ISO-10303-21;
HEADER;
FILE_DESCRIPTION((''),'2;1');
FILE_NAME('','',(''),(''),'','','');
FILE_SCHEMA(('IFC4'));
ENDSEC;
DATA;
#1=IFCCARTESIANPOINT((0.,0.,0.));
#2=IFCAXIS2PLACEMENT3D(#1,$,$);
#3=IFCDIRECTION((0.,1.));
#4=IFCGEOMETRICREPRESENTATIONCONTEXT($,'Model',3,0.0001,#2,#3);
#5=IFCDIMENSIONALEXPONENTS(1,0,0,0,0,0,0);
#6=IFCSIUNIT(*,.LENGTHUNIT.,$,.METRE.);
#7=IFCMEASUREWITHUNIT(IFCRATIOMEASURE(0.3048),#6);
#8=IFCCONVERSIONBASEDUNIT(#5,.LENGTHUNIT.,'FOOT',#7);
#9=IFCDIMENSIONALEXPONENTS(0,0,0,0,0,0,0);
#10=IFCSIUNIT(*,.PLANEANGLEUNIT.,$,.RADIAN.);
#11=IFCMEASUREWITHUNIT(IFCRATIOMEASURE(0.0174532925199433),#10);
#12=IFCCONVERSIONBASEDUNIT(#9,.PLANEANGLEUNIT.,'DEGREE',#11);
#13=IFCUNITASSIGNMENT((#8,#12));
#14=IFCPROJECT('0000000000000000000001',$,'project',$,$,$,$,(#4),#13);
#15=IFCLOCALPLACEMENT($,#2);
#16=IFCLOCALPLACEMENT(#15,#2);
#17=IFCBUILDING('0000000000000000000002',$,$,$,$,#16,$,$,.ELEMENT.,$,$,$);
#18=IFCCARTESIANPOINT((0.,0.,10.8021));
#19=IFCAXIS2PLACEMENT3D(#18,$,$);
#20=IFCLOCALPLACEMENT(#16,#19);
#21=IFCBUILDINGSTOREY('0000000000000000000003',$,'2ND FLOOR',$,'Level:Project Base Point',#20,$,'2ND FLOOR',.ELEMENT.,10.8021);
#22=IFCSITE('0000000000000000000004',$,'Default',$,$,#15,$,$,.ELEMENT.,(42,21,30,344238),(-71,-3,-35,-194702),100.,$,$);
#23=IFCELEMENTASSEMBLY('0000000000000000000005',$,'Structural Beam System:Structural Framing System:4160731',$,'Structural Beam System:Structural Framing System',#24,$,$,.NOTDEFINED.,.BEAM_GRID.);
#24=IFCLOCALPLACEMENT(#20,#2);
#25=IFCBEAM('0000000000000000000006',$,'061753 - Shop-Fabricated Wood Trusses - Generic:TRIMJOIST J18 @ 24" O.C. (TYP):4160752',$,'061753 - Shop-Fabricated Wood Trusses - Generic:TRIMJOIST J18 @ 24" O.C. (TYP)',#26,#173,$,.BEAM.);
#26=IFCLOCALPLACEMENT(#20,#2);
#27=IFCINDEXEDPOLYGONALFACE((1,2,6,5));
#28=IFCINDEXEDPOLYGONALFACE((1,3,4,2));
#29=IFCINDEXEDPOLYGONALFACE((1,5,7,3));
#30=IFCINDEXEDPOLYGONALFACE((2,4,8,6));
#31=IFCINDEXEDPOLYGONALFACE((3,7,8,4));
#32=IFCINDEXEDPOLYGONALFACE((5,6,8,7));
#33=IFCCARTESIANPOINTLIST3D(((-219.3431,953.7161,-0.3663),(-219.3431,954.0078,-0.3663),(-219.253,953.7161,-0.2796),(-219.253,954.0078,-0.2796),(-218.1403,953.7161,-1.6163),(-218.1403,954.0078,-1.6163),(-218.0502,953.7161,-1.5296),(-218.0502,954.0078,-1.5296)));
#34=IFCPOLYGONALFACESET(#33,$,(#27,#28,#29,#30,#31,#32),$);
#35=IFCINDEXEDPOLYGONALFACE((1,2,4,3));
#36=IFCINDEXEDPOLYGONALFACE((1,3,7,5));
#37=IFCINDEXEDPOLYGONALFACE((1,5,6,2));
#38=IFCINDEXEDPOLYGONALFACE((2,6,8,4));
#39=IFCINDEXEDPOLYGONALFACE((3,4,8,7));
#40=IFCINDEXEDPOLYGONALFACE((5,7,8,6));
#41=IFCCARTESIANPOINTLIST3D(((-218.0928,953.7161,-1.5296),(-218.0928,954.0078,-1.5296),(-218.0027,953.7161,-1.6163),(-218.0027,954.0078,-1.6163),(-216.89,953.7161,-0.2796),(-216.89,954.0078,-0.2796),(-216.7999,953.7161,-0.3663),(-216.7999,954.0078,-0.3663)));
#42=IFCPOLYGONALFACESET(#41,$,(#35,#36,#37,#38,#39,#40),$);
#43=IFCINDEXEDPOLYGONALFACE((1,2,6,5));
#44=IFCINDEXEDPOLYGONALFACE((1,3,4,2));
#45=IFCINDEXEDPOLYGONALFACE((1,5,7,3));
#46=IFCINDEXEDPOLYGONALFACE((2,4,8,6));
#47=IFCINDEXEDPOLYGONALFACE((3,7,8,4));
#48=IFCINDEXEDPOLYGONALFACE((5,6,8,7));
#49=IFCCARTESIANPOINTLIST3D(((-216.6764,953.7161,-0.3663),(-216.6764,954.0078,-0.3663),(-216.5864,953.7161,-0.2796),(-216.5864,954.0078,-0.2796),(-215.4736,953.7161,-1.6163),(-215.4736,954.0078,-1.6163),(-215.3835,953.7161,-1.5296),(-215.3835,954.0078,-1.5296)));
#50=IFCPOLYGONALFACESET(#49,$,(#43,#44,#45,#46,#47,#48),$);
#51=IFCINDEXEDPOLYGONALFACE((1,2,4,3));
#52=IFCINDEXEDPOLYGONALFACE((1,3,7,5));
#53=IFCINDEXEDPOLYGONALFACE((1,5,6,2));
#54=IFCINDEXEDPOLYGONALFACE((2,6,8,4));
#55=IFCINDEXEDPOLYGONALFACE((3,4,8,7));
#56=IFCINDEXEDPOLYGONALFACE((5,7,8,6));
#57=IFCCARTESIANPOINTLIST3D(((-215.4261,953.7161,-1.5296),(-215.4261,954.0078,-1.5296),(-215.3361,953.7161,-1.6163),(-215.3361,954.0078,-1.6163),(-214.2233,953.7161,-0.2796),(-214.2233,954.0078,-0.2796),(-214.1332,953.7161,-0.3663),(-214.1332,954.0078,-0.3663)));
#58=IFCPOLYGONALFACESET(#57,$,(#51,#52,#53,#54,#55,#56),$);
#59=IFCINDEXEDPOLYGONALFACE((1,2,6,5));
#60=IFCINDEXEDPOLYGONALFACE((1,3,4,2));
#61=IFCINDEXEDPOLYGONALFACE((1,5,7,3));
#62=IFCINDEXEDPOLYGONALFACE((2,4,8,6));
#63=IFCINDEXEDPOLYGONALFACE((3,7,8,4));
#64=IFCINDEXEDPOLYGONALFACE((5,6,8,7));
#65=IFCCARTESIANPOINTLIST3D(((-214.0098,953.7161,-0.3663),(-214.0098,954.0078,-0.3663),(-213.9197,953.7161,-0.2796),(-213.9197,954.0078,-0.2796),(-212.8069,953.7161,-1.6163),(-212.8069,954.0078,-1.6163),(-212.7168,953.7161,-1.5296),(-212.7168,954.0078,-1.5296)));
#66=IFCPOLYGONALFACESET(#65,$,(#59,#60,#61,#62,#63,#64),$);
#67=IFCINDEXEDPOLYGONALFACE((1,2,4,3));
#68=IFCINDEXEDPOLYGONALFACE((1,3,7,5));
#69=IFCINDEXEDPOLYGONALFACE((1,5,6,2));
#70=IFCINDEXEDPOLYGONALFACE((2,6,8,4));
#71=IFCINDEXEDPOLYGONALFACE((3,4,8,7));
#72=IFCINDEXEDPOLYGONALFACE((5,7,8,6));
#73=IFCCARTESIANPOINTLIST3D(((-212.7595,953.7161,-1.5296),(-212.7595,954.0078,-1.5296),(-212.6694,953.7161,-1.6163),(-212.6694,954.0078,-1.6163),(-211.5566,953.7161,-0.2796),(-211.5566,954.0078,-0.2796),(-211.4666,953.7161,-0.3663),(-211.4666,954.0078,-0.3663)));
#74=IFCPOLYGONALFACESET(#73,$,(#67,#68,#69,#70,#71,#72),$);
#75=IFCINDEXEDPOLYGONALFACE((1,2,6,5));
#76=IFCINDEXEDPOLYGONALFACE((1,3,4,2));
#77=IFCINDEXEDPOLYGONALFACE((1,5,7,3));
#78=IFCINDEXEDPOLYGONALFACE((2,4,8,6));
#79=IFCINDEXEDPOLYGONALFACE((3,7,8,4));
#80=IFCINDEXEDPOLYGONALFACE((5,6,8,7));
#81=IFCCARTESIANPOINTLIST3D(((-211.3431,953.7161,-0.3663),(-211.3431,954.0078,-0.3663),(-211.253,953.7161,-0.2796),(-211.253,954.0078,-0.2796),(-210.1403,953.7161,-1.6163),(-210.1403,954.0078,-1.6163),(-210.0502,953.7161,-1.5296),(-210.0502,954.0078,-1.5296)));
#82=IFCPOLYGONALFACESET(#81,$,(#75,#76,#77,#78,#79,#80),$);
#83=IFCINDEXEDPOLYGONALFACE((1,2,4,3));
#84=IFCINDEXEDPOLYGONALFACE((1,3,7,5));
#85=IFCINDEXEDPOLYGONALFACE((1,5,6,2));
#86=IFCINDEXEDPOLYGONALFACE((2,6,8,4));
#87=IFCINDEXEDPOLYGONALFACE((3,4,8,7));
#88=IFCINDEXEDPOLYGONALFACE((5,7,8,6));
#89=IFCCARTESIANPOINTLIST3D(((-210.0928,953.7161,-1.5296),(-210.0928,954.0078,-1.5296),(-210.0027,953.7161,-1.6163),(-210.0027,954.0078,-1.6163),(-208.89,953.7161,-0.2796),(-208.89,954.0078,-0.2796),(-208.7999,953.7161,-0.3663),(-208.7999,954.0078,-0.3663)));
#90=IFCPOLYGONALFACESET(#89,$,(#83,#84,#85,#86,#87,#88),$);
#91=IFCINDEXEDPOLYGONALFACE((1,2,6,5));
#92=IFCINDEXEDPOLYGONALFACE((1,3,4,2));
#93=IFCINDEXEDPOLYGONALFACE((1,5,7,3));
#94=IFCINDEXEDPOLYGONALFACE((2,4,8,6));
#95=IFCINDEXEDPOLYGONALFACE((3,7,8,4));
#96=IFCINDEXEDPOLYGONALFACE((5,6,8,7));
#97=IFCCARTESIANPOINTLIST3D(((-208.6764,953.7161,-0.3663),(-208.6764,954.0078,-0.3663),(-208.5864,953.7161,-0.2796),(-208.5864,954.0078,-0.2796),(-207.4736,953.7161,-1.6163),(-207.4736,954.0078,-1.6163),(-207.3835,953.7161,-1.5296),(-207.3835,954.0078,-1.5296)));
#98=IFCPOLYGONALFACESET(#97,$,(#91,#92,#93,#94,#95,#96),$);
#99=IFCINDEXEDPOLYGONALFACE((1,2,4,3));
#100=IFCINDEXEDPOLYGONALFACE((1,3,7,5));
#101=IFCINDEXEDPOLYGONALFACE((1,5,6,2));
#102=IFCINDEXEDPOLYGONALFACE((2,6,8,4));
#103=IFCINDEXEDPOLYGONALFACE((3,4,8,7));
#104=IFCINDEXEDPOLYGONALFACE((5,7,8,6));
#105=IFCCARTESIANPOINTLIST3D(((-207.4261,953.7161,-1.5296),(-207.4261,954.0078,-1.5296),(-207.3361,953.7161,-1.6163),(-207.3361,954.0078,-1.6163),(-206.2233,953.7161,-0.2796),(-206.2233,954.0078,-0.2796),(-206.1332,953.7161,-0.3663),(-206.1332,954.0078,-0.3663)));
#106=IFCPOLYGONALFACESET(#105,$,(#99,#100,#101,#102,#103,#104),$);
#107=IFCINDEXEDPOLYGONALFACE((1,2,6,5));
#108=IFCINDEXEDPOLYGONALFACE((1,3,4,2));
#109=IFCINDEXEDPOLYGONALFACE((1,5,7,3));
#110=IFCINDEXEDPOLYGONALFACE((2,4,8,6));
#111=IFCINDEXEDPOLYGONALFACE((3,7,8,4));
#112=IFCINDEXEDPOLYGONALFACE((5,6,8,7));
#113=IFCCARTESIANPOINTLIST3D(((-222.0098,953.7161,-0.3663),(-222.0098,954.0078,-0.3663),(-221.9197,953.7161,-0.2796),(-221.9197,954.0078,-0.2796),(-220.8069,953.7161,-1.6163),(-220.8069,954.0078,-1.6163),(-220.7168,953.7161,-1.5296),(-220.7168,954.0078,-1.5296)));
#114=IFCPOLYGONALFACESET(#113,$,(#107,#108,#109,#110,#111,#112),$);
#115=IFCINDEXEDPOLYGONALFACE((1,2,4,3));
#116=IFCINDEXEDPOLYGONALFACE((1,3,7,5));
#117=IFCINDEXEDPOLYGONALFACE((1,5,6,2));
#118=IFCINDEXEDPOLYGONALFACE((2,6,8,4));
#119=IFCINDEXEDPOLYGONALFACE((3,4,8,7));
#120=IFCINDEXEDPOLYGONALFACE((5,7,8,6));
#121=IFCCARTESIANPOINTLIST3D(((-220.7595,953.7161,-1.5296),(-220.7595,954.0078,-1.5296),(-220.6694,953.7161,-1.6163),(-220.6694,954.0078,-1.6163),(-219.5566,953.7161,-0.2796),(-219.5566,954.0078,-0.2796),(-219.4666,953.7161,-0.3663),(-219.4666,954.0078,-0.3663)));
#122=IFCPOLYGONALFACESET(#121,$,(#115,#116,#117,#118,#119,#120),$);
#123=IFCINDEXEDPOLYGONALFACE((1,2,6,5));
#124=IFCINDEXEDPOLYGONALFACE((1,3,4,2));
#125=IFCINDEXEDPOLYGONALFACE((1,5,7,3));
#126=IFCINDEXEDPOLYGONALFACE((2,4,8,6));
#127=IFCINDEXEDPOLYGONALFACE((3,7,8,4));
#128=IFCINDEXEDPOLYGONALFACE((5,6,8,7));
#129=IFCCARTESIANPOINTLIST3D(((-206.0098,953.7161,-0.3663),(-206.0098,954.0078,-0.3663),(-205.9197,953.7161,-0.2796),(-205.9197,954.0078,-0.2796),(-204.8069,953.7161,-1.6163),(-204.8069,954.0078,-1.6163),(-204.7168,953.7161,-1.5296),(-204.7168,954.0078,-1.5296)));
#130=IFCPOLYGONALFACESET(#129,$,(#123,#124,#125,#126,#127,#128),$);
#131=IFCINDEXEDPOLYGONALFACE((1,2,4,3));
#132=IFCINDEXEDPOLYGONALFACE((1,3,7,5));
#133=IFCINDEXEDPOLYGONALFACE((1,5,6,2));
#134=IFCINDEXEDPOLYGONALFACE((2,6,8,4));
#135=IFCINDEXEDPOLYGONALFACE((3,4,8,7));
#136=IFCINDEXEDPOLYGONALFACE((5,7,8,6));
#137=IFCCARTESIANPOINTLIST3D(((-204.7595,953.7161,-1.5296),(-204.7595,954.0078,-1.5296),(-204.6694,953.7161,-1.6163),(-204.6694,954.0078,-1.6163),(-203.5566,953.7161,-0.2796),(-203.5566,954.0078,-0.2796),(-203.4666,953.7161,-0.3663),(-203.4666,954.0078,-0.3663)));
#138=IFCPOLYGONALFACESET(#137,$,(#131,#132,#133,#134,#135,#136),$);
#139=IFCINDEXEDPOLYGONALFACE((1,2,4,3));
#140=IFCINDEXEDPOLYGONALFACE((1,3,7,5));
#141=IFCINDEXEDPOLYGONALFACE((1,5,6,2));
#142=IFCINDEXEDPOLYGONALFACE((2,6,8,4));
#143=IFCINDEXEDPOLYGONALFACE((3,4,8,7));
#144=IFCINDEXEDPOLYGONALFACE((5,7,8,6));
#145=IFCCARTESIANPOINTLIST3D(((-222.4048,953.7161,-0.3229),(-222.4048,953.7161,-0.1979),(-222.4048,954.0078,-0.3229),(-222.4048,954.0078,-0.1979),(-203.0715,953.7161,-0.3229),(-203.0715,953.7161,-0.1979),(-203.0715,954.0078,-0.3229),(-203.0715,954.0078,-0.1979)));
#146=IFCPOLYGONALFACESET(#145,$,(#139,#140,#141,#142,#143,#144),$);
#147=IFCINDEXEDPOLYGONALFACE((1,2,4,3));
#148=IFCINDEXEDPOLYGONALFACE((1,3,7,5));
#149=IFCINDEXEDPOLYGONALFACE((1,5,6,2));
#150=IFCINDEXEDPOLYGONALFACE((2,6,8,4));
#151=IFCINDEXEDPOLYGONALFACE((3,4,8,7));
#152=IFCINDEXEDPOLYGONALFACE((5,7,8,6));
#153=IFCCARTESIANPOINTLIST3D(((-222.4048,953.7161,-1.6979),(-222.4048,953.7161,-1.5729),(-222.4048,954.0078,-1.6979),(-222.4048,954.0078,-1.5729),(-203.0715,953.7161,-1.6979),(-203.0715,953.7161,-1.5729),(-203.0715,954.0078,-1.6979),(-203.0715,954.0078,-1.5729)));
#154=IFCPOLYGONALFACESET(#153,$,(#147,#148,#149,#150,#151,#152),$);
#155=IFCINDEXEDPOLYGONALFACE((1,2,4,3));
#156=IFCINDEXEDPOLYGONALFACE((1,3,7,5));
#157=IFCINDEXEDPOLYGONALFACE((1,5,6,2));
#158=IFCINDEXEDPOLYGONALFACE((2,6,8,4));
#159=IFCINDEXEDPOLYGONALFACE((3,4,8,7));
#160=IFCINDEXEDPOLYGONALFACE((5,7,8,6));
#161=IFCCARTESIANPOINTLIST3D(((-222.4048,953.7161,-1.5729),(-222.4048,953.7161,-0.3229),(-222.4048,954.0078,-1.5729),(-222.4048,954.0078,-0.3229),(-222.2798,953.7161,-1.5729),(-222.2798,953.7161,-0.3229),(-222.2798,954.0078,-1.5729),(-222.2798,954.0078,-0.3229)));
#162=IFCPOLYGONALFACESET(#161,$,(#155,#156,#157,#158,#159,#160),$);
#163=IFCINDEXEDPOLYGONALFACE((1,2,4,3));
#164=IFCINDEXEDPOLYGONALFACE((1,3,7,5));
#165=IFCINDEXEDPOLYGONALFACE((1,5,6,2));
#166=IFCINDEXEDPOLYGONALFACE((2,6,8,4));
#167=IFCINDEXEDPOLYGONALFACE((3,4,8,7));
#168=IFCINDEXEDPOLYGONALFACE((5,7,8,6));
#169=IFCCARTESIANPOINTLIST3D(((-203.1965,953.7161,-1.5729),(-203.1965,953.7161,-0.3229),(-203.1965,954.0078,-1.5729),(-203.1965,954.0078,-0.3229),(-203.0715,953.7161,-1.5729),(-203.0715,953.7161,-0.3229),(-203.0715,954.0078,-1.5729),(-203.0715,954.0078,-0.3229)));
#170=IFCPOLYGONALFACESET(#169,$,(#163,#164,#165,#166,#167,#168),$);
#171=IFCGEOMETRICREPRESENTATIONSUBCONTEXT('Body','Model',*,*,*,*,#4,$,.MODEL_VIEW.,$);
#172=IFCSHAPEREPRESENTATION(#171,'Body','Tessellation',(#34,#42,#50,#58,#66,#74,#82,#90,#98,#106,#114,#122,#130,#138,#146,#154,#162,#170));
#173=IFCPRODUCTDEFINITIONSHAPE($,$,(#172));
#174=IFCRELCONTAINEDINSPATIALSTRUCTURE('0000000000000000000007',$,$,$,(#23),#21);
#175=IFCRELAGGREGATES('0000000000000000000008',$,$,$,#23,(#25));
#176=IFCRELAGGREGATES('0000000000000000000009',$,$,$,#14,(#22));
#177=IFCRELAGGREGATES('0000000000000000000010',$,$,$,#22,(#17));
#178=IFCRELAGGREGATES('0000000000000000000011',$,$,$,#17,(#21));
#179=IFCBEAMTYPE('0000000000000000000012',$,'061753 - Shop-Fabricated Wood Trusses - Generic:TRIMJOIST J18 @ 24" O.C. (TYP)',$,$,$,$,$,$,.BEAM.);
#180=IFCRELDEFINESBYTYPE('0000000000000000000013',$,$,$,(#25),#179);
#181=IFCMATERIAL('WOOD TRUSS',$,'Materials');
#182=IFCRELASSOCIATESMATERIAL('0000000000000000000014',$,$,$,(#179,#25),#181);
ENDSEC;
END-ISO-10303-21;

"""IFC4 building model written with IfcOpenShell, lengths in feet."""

from ifc_helpers import new_model, entity, si_unit, converted_unit, direction, frame, frame_2d, origin, origin_2d_with_axis, place, context, subcontext, project, spatial, rectangle, extrude, source, transform, mapped, material, material_profile, profile_set, profile_usage, type_object, type_shapes, element, aggregate, save


model = new_model("IFC4")

# Units and contexts
model_context = context("Model", 3, precision=0.0001, world=origin(), true_north=direction((0.0, 1.0)))
body_context = subcontext(model_context, "Body", "Model", "MODEL_VIEW")
ifc_project = project(units=[converted_unit("LENGTHUNIT", "FOOT", entity("IfcRatioMeasure", 0.3048), si_unit("LENGTHUNIT", "METRE"), dimensions=[1, 0, 0, 0, 0, 0, 0]), converted_unit("PLANEANGLEUNIT", "DEGREE", entity("IfcRatioMeasure", 0.0174532925199433), si_unit("PLANEANGLEUNIT", "RADIAN"), dimensions=[0, 0, 0, 0, 0, 0, 0])], contexts=[model_context])

# Site, building, storey
site_placement = place(None, origin())
site = spatial("IfcSite", under=ifc_project, at=site_placement, Name="Default", CompositionType="ELEMENT", RefLatitude=(42, 21, 30, 344238), RefLongitude=(-71, -3, -35, -194702), RefElevation=100.0)
building_placement = place(site_placement, origin())
building = spatial("IfcBuilding", under=site, at=building_placement, CompositionType="ELEMENT")
storey_placement = place(building_placement, frame((0.0, 0.0, 10.8021)))
storey = spatial("IfcBuildingStorey", under=building, at=storey_placement, Name="2ND FLOOR", ObjectType="Level:Project Base Point", LongName="2ND FLOOR", CompositionType="ELEMENT", Elevation=10.8021)

# Element assembly, beam
ifc_material_1 = material(Name="WOOD TRUSS", Category="Materials")
ifc_material_profile_1 = material_profile(ifc_material_1, rectangle(XDim=1.7347, YDim=0.125, at=frame_2d((0.0, 0.0), x_axis=(1.0, 0.0))), Name="TRIMJOIST J18 @ 24\" O.C. (TYP)")
ifc_material_profile_2 = material_profile(ifc_material_1, rectangle(XDim=1.7347, YDim=0.125, at=frame_2d((0.0, 0.0), x_axis=(1.0, 0.0))), Name="TRIMJOIST J18 @ 24\" O.C. (TYP)")
ifc_material_profile_3 = material_profile(ifc_material_1, rectangle(XDim=1.7347, YDim=0.125, at=frame_2d((0.0, 0.0), x_axis=(1.0, 0.0))), Name="TRIMJOIST J18 @ 24\" O.C. (TYP)")
ifc_material_profile_4 = material_profile(ifc_material_1, rectangle(XDim=1.7347, YDim=0.125, at=frame_2d((0.0, 0.0), x_axis=(1.0, 0.0))), Name="TRIMJOIST J18 @ 24\" O.C. (TYP)")
ifc_material_profile_5 = material_profile(ifc_material_1, rectangle(XDim=1.7347, YDim=0.125, at=frame_2d((0.0, 0.0), x_axis=(1.0, 0.0))), Name="TRIMJOIST J18 @ 24\" O.C. (TYP)")
ifc_material_profile_6 = material_profile(ifc_material_1, rectangle(XDim=1.7347, YDim=0.125, at=frame_2d((0.0, 0.0), x_axis=(1.0, 0.0))), Name="TRIMJOIST J18 @ 24\" O.C. (TYP)")
ifc_material_profile_7 = material_profile(ifc_material_1, rectangle(XDim=1.7347, YDim=0.125, at=frame_2d((0.0, 0.0), x_axis=(1.0, 0.0))), Name="TRIMJOIST J18 @ 24\" O.C. (TYP)")
ifc_material_profile_8 = material_profile(ifc_material_1, rectangle(XDim=1.7347, YDim=0.125, at=frame_2d((0.0, 0.0), x_axis=(1.0, 0.0))), Name="TRIMJOIST J18 @ 24\" O.C. (TYP)")
ifc_material_profile_9 = material_profile(ifc_material_1, rectangle(XDim=1.7347, YDim=0.125, at=frame_2d((0.0, 0.0), x_axis=(1.0, 0.0))), Name="TRIMJOIST J18 @ 24\" O.C. (TYP)")
ifc_material_profile_10 = material_profile(ifc_material_1, rectangle(XDim=1.7347, YDim=0.125, at=origin_2d_with_axis()), Name="TRIMJOIST J18 @ 24\" O.C. (TYP)")
ifc_material_profile_11 = material_profile(ifc_material_1, rectangle(XDim=0.125, YDim=0.2917, at=origin_2d_with_axis()), Name="TRIMJOIST J18 @ 24\" O.C. (TYP)")
ifc_material_profile_12 = material_profile(ifc_material_1, rectangle(XDim=0.125, YDim=0.2917, at=origin_2d_with_axis()), Name="TRIMJOIST J18 @ 24\" O.C. (TYP)")
ifc_material_profile_13 = material_profile(ifc_material_1, rectangle(XDim=1.25, YDim=0.2917, at=origin_2d_with_axis()), Name="TRIMJOIST J18 @ 24\" O.C. (TYP)")
ifc_material_profile_14 = material_profile(ifc_material_1, rectangle(XDim=1.25, YDim=0.2917, at=origin_2d_with_axis()), Name="TRIMJOIST J18 @ 24\" O.C. (TYP)")
ifc_profile_set_1 = profile_set([ifc_material_profile_1, ifc_material_profile_2, ifc_material_profile_3, ifc_material_profile_4, ifc_material_profile_5, ifc_material_profile_6, ifc_material_profile_7, ifc_material_profile_8, ifc_material_profile_9, ifc_material_profile_10, ifc_material_profile_11, ifc_material_profile_12, ifc_material_profile_13, ifc_material_profile_14], Name="TRIMJOIST J18 @ 24\" O.C. (TYP)")
beam_type_1 = type_object("IfcBeamType", Name="061753 - Shop-Fabricated Wood Trusses - Generic:TRIMJOIST J18 @ 24\" O.C. (TYP)", PredefinedType="BEAM", material=ifc_profile_set_1)
shared_shape_1 = source(origin(), body_context, "Body", "SweptSolid", [
    extrude(rectangle(XDim=1.7347, YDim=0.125, at=frame_2d((0.0, 0.0), x_axis=(1.0, 0.0))), frame((5.9585, -0.1458, 0.0), z_axis=(0.0, 1.0, 0.0), x_axis=(0.693383, 0.0, 0.720569)), (0.0, 0.0, 1.0), 0.2917),
    extrude(rectangle(XDim=1.7347, YDim=0.125, at=origin_2d_with_axis()), frame((4.7082, -0.1458, 0.0), z_axis=(0.0, 1.0, 0.0), x_axis=(0.693383, 0.0, -0.720569)), (0.0, 0.0, 1.0), 0.2917),
    extrude(rectangle(XDim=1.7347, YDim=0.125, at=frame_2d((0.0, 0.0), x_axis=(1.0, 0.0))), frame((3.2918, -0.1458, 0.0), z_axis=(0.0, 1.0, 0.0), x_axis=(0.693383, 0.0, 0.720569)), (0.0, 0.0, 1.0), 0.2917),
    extrude(rectangle(XDim=1.7347, YDim=0.125, at=frame_2d((0.0, 0.0), x_axis=(1.0, 0.0))), frame((2.0415, -0.1458, 0.0), z_axis=(0.0, 1.0, 0.0), x_axis=(0.693383, 0.0, -0.720569)), (0.0, 0.0, 1.0), 0.2917),
    extrude(rectangle(XDim=1.7347, YDim=0.125, at=frame_2d((0.0, 0.0), x_axis=(1.0, 0.0))), frame((0.6251, -0.1458, 0.0), z_axis=(0.0, 1.0, 0.0), x_axis=(0.693383, 0.0, 0.720569)), (0.0, 0.0, 1.0), 0.2917),
    extrude(rectangle(XDim=1.7347, YDim=0.125, at=frame_2d((0.0, 0.0), x_axis=(1.0, 0.0))), frame((-0.6251, -0.1458, 0.0), z_axis=(0.0, 1.0, 0.0), x_axis=(0.693383, 0.0, -0.720569)), (0.0, 0.0, 1.0), 0.2917),
    extrude(rectangle(XDim=1.7347, YDim=0.125, at=frame_2d((0.0, 0.0), x_axis=(1.0, 0.0))), frame((-2.0415, -0.1458, 0.0), z_axis=(0.0, 1.0, 0.0), x_axis=(0.693383, 0.0, 0.720569)), (0.0, 0.0, 1.0), 0.2917),
    extrude(rectangle(XDim=1.7347, YDim=0.125, at=origin_2d_with_axis()), frame((-3.2918, -0.1458, 0.0), z_axis=(0.0, 1.0, 0.0), x_axis=(0.693383, 0.0, -0.720569)), (0.0, 0.0, 1.0), 0.2917),
    extrude(rectangle(XDim=1.7347, YDim=0.125, at=frame_2d((0.0, 0.0), x_axis=(1.0, 0.0))), frame((-4.7082, -0.1458, 0.0), z_axis=(0.0, 1.0, 0.0), x_axis=(0.693383, 0.0, 0.720569)), (0.0, 0.0, 1.0), 0.2917),
    extrude(rectangle(XDim=1.7347, YDim=0.125, at=frame_2d((0.0, 0.0), x_axis=(1.0, 0.0))), frame((-5.9585, -0.1458, 0.0), z_axis=(0.0, 1.0, 0.0), x_axis=(0.693383, 0.0, -0.720569)), (0.0, 0.0, 1.0), 0.2917),
    extrude(rectangle(XDim=1.7347, YDim=0.125, at=frame_2d((0.0, 0.0), x_axis=(1.0, 0.0))), frame((8.6251, -0.1458, 0.0), z_axis=(0.0, 1.0, 0.0), x_axis=(0.693383, 0.0, 0.720569)), (0.0, 0.0, 1.0), 0.2917),
    extrude(rectangle(XDim=1.7347, YDim=0.125, at=origin_2d_with_axis()), frame((7.3749, -0.1458, 0.0), z_axis=(0.0, 1.0, 0.0), x_axis=(0.693383, 0.0, -0.720569)), (0.0, 0.0, 1.0), 0.2917),
    extrude(rectangle(XDim=1.7347, YDim=0.125, at=frame_2d((0.0, 0.0), x_axis=(1.0, 0.0))), frame((-7.3749, -0.1458, 0.0), z_axis=(0.0, 1.0, 0.0), x_axis=(0.693383, 0.0, 0.720569)), (0.0, 0.0, 1.0), 0.2917),
    extrude(rectangle(XDim=1.7347, YDim=0.125, at=origin_2d_with_axis()), frame((-8.6251, -0.1458, 0.0), z_axis=(0.0, 1.0, 0.0), x_axis=(0.693383, 0.0, -0.720569)), (0.0, 0.0, 1.0), 0.2917),
    extrude(rectangle(XDim=0.125, YDim=0.2917, at=origin_2d_with_axis()), frame((-9.6667, 0.0, 0.6875), z_axis=(1.0, 0.0, 0.0), x_axis=(0.0, 0.0, -1.0)), (0.0, 0.0, 1.0), 19.3333),
    extrude(rectangle(XDim=0.125, YDim=0.2917, at=origin_2d_with_axis()), frame((-9.6667, 0.0, -0.6875), z_axis=(1.0, 0.0, 0.0), x_axis=(0.0, 0.0, -1.0)), (0.0, 0.0, 1.0), 19.3333),
    extrude(rectangle(XDim=1.25, YDim=0.2917, at=origin_2d_with_axis()), frame((9.5417, 0.0, 0.0), z_axis=(1.0, 0.0, 0.0), x_axis=(0.0, 0.0, -1.0)), (0.0, 0.0, 1.0), 0.125),
    extrude(rectangle(XDim=1.25, YDim=0.2917, at=origin_2d_with_axis()), frame((-9.6667, 0.0, 0.0), z_axis=(1.0, 0.0, 0.0), x_axis=(0.0, 0.0, -1.0)), (0.0, 0.0, 1.0), 0.125),
])
type_shapes(beam_type_1, [shared_shape_1])
assembly_1_placement = place(storey_placement, origin())
assembly_1 = element("IfcElementAssembly", 1, at=assembly_1_placement, inside=storey, Name="Structural Beam System:Structural Framing System:4160731", ObjectType="Structural Beam System:Structural Framing System", AssemblyPlace="NOTDEFINED", PredefinedType="BEAM_GRID")
ifc_profile_usage_1 = profile_usage(ifc_profile_set_1, cardinal=8)
beam_1_placement = place(assembly_1_placement, frame((-212.7382, 953.8619, -0.9479), z_axis=(0.0, 0.0, 1.0), x_axis=(-1.0, 0.0, 0.0)))
beam_1 = element("IfcBeam", 2, at=beam_1_placement, type_object=beam_type_1, material=ifc_profile_usage_1, Name="061753 - Shop-Fabricated Wood Trusses - Generic:TRIMJOIST J18 @ 24\" O.C. (TYP):4160752", ObjectType="061753 - Shop-Fabricated Wood Trusses - Generic:TRIMJOIST J18 @ 24\" O.C. (TYP)", PredefinedType="BEAM", context=body_context, shape_type="MappedRepresentation", body=[
    mapped(shared_shape_1, transform((0.0, 0.0, 0.0), scale=1.0)),
])
aggregate(assembly_1, [beam_1])

save(model, "model.ifc")
